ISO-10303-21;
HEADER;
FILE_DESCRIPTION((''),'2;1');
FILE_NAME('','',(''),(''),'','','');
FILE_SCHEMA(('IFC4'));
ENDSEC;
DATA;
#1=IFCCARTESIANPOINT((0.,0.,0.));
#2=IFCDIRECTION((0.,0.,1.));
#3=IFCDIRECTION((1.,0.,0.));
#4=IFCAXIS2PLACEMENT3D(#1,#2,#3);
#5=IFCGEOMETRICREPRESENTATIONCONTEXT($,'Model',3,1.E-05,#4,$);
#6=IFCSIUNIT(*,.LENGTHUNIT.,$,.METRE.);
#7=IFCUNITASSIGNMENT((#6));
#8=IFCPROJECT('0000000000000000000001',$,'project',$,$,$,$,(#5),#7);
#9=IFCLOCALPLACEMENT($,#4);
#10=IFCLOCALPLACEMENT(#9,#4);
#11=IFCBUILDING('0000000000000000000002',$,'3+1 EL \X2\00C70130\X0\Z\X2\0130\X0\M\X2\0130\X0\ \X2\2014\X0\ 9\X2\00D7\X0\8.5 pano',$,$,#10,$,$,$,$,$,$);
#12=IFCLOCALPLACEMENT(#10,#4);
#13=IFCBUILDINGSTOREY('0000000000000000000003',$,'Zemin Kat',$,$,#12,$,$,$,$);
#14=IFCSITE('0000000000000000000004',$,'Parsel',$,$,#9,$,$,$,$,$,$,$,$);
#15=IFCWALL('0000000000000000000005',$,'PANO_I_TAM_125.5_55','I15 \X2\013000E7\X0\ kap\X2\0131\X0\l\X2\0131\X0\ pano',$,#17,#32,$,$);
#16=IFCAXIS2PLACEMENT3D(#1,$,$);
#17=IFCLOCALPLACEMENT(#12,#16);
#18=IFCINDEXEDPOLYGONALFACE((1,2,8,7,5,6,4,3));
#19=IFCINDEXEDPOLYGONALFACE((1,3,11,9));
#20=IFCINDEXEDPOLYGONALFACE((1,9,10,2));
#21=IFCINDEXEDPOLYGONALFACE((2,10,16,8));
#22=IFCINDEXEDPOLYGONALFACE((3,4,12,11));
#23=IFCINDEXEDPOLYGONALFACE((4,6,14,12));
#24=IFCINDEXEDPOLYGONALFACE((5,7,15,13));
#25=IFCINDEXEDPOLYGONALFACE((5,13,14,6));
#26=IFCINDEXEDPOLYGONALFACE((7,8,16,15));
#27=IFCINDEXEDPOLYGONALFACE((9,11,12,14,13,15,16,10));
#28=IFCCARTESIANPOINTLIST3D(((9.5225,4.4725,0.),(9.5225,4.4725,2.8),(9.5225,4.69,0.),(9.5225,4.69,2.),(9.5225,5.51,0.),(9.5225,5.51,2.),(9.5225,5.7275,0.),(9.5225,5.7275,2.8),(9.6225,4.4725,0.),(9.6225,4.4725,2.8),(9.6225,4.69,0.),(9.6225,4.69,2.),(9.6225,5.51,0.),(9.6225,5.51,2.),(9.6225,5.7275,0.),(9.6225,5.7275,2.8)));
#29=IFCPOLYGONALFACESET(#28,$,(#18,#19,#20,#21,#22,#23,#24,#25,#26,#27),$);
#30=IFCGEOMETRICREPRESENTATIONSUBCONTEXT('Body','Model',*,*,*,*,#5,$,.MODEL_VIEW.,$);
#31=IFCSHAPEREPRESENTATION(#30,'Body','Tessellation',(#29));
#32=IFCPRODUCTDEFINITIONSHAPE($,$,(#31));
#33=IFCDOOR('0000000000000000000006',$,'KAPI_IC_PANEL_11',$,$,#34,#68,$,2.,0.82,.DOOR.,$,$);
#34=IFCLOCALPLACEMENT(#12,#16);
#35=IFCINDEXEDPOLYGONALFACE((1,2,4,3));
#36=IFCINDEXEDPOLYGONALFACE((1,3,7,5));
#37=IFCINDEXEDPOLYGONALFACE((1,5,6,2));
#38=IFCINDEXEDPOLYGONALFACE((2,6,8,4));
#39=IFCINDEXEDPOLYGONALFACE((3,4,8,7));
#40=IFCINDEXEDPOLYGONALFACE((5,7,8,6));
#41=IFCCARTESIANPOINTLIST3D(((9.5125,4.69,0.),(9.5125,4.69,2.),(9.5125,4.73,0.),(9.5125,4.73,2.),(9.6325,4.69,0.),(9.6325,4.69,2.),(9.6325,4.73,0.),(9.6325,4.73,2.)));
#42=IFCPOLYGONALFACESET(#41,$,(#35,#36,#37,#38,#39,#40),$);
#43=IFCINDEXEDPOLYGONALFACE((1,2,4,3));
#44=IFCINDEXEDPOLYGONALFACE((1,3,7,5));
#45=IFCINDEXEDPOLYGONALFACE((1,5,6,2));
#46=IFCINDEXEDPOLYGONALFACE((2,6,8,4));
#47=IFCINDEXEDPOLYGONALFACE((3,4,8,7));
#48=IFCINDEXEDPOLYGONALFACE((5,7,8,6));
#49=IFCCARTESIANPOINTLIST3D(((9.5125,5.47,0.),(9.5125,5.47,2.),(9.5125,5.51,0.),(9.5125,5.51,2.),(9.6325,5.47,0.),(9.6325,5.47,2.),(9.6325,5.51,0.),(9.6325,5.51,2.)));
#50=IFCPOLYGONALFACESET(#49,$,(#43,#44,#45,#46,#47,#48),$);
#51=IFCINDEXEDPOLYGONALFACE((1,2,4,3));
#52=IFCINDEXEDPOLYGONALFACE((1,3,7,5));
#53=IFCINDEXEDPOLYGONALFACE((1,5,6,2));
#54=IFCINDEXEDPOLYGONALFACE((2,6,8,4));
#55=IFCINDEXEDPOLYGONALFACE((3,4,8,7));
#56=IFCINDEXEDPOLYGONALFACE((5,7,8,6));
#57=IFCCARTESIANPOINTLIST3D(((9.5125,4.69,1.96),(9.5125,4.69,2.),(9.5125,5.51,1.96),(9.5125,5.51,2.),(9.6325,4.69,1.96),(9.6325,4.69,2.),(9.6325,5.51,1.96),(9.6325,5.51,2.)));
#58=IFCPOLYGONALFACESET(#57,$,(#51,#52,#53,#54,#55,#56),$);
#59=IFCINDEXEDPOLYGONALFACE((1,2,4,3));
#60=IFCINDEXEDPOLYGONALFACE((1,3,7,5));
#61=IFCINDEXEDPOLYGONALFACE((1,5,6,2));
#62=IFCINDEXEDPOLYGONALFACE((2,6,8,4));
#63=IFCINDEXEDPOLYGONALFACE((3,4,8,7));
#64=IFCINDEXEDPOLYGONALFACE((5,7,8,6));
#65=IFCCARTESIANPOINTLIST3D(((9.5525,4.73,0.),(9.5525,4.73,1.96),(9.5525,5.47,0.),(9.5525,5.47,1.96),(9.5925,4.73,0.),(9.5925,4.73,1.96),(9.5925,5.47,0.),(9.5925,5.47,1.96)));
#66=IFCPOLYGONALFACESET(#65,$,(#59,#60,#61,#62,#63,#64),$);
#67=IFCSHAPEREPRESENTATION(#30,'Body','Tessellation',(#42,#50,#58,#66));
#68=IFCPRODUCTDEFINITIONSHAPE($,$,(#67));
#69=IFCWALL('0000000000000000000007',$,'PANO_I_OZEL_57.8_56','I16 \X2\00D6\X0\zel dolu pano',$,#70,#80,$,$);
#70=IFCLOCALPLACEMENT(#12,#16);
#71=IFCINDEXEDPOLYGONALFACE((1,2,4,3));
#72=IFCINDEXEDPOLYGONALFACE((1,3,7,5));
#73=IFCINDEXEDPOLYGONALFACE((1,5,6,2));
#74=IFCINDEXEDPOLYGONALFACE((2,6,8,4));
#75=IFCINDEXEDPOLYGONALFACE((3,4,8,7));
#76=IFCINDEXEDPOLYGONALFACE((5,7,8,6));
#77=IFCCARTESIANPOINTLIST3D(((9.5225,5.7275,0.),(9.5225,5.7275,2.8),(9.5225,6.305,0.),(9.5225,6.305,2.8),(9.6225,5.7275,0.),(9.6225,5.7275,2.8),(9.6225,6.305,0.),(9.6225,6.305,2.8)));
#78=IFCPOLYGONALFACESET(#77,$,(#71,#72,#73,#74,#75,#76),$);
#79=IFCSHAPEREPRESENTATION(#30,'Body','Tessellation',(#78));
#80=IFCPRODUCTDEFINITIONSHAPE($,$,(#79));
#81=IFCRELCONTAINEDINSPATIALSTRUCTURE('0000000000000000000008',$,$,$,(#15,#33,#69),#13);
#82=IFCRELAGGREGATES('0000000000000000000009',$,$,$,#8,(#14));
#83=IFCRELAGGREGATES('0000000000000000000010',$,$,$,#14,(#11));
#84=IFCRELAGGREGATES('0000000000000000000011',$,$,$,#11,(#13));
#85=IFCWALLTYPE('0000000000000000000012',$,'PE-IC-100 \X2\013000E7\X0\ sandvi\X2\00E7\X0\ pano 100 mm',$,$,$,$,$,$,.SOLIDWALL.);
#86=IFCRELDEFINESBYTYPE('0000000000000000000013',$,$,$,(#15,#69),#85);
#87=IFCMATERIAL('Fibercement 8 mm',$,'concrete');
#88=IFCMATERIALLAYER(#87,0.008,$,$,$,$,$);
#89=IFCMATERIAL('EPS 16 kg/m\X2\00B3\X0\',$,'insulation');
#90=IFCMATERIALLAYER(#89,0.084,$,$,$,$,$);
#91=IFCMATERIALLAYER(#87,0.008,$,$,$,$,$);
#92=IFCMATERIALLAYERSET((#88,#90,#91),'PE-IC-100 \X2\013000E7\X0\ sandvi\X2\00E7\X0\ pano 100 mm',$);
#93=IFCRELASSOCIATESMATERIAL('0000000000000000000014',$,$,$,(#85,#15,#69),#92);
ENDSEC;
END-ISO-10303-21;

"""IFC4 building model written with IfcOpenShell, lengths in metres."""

from ifc_helpers import new_model, si_unit, frame, origin_with_axes, place, context, subcontext, project, spatial, line, indexed_curve, outline, extrude, material, layer, layer_set, layer_usage, type_object, element, fill, save


model = new_model("IFC4")

# Units and contexts
model_context = context("Model", 3, precision=1e-05, world=origin_with_axes())
body_context = subcontext(model_context, "Body", "Model", "MODEL_VIEW")
ifc_project = project(units=[si_unit("LENGTHUNIT", "METRE")], contexts=[model_context])

# Site, building, storey
site_placement = place(None, origin_with_axes())
site = spatial("IfcSite", under=ifc_project, at=site_placement, Name="Parsel")
building_placement = place(site_placement, origin_with_axes())
building = spatial("IfcBuilding", under=site, at=building_placement, Name="3+1 EL ÇİZİMİ — 9×8.5 pano")
storey_placement = place(building_placement, origin_with_axes())
storey = spatial("IfcBuildingStorey", under=building, at=storey_placement, Name="Zemin Kat")

# Shared definitions
ifc_material_1 = material(Name="Fibercement 8 mm", Category="concrete")
ifc_material_2 = material(Name="EPS 16 kg/m³", Category="insulation")

# Shared definitions
ifc_layer_1 = layer(ifc_material_1, 0.008)
ifc_layer_2 = layer(ifc_material_2, 0.084)
ifc_layer_3 = layer(ifc_material_1, 0.008)
ifc_layer_set_1 = layer_set([ifc_layer_1, ifc_layer_2, ifc_layer_3], Name="PE-IC-100 İç sandviç pano 100 mm")
wall_type_1 = type_object("IfcWallType", Name="PE-IC-100 İç sandviç pano 100 mm", PredefinedType="SOLIDWALL", material=ifc_layer_set_1)

# Wall, opening, door
ifc_layer_usage_1 = layer_usage(ifc_layer_set_1, "AXIS2", "POSITIVE", 0.0)
wall_1_placement = place(storey_placement, frame((9.6225, 4.4725, 0.0), z_axis=(0.0, 0.0, 1.0), x_axis=(0.0, 1.0, 0.0)))
wall_1 = element("IfcWall", 1, at=wall_1_placement, inside=storey, type_object=wall_type_1, material=ifc_layer_usage_1, Name="PANO_I_TAM_125.5_55", Description="I15 İç kapılı pano", context=body_context, shape_type="SweptSolid", body=[
    extrude(outline(indexed_curve([(0.0, 0.0), (1.255, 0.0), (1.255, 0.1), (0.0, 0.1)], segments=[line(1, 2, 3, 4, 1)])), origin_with_axes(), (0.0, 0.0, 1.0), 2.8),
])
opening_1_placement = place(wall_1_placement, origin_with_axes())
opening_1 = element("IfcOpeningElement", 2, at=opening_1_placement, cuts=wall_1, PredefinedType="OPENING", context=body_context, shape_type="SweptSolid", body=[
    extrude(outline(indexed_curve([(0.0, 0.0), (0.82, 0.0), (0.82, 0.14), (0.0, 0.14)], segments=[line(1, 2, 3, 4, 1)])), frame((0.2175, -0.02, 0.0), z_axis=(0.0, 0.0, 1.0), x_axis=(1.0, 0.0, 0.0)), (0.0, 0.0, 1.0), 2.0),
])
door_1_placement = place(storey_placement, frame((9.6225, 4.4725, 0.0), z_axis=(0.0, 0.0, 1.0), x_axis=(0.0, 1.0, 0.0)))
door_1 = element("IfcDoor", 3, at=door_1_placement, inside=storey, Name="KAPI_IC_PANEL_11", OverallHeight=2.0, OverallWidth=0.82, PredefinedType="DOOR", context=body_context, shape_type="SweptSolid", body=[
    extrude(outline(indexed_curve([(0.0, 0.0), (0.04, 0.0), (0.04, 0.12), (0.0, 0.12)], segments=[line(1, 2, 3, 4, 1)])), frame((0.2175, -0.01, 0.0), z_axis=(0.0, 0.0, 1.0), x_axis=(1.0, 0.0, 0.0)), (0.0, 0.0, 1.0), 2.0),
    extrude(outline(indexed_curve([(0.0, 0.0), (0.04, 0.0), (0.04, 0.12), (0.0, 0.12)], segments=[line(1, 2, 3, 4, 1)])), frame((0.9975, -0.01, 0.0), z_axis=(0.0, 0.0, 1.0), x_axis=(1.0, 0.0, 0.0)), (0.0, 0.0, 1.0), 2.0),
    extrude(outline(indexed_curve([(0.0, 0.0), (0.82, 0.0), (0.82, 0.12), (0.0, 0.12)], segments=[line(1, 2, 3, 4, 1)])), frame((0.2175, -0.01, 1.96), z_axis=(0.0, 0.0, 1.0), x_axis=(1.0, 0.0, 0.0)), (0.0, 0.0, 1.0), 0.04),
    extrude(outline(indexed_curve([(0.0, 0.0), (0.74, 0.0), (0.74, 0.04), (0.0, 0.04)], segments=[line(1, 2, 3, 4, 1)])), frame((0.2575, 0.03, 0.0), z_axis=(0.0, 0.0, 1.0), x_axis=(1.0, 0.0, 0.0)), (0.0, 0.0, 1.0), 1.96),
])
fill(opening_1, door_1)

# Wall
ifc_layer_usage_2 = layer_usage(ifc_layer_set_1, "AXIS2", "POSITIVE", 0.0)
wall_2_placement = place(storey_placement, frame((9.6225, 5.7275, 0.0), z_axis=(0.0, 0.0, 1.0), x_axis=(0.0, 1.0, 0.0)))
element("IfcWall", 4, at=wall_2_placement, inside=storey, type_object=wall_type_1, material=ifc_layer_usage_2, Name="PANO_I_OZEL_57.8_56", Description="I16 Özel dolu pano", context=body_context, shape_type="SweptSolid", body=[
    extrude(outline(indexed_curve([(0.0, 0.0), (0.5775, 0.0), (0.5775, 0.1), (0.0, 0.1)], segments=[line(1, 2, 3, 4, 1)])), origin_with_axes(), (0.0, 0.0, 1.0), 2.8),
])

save(model, "model.ifc")
